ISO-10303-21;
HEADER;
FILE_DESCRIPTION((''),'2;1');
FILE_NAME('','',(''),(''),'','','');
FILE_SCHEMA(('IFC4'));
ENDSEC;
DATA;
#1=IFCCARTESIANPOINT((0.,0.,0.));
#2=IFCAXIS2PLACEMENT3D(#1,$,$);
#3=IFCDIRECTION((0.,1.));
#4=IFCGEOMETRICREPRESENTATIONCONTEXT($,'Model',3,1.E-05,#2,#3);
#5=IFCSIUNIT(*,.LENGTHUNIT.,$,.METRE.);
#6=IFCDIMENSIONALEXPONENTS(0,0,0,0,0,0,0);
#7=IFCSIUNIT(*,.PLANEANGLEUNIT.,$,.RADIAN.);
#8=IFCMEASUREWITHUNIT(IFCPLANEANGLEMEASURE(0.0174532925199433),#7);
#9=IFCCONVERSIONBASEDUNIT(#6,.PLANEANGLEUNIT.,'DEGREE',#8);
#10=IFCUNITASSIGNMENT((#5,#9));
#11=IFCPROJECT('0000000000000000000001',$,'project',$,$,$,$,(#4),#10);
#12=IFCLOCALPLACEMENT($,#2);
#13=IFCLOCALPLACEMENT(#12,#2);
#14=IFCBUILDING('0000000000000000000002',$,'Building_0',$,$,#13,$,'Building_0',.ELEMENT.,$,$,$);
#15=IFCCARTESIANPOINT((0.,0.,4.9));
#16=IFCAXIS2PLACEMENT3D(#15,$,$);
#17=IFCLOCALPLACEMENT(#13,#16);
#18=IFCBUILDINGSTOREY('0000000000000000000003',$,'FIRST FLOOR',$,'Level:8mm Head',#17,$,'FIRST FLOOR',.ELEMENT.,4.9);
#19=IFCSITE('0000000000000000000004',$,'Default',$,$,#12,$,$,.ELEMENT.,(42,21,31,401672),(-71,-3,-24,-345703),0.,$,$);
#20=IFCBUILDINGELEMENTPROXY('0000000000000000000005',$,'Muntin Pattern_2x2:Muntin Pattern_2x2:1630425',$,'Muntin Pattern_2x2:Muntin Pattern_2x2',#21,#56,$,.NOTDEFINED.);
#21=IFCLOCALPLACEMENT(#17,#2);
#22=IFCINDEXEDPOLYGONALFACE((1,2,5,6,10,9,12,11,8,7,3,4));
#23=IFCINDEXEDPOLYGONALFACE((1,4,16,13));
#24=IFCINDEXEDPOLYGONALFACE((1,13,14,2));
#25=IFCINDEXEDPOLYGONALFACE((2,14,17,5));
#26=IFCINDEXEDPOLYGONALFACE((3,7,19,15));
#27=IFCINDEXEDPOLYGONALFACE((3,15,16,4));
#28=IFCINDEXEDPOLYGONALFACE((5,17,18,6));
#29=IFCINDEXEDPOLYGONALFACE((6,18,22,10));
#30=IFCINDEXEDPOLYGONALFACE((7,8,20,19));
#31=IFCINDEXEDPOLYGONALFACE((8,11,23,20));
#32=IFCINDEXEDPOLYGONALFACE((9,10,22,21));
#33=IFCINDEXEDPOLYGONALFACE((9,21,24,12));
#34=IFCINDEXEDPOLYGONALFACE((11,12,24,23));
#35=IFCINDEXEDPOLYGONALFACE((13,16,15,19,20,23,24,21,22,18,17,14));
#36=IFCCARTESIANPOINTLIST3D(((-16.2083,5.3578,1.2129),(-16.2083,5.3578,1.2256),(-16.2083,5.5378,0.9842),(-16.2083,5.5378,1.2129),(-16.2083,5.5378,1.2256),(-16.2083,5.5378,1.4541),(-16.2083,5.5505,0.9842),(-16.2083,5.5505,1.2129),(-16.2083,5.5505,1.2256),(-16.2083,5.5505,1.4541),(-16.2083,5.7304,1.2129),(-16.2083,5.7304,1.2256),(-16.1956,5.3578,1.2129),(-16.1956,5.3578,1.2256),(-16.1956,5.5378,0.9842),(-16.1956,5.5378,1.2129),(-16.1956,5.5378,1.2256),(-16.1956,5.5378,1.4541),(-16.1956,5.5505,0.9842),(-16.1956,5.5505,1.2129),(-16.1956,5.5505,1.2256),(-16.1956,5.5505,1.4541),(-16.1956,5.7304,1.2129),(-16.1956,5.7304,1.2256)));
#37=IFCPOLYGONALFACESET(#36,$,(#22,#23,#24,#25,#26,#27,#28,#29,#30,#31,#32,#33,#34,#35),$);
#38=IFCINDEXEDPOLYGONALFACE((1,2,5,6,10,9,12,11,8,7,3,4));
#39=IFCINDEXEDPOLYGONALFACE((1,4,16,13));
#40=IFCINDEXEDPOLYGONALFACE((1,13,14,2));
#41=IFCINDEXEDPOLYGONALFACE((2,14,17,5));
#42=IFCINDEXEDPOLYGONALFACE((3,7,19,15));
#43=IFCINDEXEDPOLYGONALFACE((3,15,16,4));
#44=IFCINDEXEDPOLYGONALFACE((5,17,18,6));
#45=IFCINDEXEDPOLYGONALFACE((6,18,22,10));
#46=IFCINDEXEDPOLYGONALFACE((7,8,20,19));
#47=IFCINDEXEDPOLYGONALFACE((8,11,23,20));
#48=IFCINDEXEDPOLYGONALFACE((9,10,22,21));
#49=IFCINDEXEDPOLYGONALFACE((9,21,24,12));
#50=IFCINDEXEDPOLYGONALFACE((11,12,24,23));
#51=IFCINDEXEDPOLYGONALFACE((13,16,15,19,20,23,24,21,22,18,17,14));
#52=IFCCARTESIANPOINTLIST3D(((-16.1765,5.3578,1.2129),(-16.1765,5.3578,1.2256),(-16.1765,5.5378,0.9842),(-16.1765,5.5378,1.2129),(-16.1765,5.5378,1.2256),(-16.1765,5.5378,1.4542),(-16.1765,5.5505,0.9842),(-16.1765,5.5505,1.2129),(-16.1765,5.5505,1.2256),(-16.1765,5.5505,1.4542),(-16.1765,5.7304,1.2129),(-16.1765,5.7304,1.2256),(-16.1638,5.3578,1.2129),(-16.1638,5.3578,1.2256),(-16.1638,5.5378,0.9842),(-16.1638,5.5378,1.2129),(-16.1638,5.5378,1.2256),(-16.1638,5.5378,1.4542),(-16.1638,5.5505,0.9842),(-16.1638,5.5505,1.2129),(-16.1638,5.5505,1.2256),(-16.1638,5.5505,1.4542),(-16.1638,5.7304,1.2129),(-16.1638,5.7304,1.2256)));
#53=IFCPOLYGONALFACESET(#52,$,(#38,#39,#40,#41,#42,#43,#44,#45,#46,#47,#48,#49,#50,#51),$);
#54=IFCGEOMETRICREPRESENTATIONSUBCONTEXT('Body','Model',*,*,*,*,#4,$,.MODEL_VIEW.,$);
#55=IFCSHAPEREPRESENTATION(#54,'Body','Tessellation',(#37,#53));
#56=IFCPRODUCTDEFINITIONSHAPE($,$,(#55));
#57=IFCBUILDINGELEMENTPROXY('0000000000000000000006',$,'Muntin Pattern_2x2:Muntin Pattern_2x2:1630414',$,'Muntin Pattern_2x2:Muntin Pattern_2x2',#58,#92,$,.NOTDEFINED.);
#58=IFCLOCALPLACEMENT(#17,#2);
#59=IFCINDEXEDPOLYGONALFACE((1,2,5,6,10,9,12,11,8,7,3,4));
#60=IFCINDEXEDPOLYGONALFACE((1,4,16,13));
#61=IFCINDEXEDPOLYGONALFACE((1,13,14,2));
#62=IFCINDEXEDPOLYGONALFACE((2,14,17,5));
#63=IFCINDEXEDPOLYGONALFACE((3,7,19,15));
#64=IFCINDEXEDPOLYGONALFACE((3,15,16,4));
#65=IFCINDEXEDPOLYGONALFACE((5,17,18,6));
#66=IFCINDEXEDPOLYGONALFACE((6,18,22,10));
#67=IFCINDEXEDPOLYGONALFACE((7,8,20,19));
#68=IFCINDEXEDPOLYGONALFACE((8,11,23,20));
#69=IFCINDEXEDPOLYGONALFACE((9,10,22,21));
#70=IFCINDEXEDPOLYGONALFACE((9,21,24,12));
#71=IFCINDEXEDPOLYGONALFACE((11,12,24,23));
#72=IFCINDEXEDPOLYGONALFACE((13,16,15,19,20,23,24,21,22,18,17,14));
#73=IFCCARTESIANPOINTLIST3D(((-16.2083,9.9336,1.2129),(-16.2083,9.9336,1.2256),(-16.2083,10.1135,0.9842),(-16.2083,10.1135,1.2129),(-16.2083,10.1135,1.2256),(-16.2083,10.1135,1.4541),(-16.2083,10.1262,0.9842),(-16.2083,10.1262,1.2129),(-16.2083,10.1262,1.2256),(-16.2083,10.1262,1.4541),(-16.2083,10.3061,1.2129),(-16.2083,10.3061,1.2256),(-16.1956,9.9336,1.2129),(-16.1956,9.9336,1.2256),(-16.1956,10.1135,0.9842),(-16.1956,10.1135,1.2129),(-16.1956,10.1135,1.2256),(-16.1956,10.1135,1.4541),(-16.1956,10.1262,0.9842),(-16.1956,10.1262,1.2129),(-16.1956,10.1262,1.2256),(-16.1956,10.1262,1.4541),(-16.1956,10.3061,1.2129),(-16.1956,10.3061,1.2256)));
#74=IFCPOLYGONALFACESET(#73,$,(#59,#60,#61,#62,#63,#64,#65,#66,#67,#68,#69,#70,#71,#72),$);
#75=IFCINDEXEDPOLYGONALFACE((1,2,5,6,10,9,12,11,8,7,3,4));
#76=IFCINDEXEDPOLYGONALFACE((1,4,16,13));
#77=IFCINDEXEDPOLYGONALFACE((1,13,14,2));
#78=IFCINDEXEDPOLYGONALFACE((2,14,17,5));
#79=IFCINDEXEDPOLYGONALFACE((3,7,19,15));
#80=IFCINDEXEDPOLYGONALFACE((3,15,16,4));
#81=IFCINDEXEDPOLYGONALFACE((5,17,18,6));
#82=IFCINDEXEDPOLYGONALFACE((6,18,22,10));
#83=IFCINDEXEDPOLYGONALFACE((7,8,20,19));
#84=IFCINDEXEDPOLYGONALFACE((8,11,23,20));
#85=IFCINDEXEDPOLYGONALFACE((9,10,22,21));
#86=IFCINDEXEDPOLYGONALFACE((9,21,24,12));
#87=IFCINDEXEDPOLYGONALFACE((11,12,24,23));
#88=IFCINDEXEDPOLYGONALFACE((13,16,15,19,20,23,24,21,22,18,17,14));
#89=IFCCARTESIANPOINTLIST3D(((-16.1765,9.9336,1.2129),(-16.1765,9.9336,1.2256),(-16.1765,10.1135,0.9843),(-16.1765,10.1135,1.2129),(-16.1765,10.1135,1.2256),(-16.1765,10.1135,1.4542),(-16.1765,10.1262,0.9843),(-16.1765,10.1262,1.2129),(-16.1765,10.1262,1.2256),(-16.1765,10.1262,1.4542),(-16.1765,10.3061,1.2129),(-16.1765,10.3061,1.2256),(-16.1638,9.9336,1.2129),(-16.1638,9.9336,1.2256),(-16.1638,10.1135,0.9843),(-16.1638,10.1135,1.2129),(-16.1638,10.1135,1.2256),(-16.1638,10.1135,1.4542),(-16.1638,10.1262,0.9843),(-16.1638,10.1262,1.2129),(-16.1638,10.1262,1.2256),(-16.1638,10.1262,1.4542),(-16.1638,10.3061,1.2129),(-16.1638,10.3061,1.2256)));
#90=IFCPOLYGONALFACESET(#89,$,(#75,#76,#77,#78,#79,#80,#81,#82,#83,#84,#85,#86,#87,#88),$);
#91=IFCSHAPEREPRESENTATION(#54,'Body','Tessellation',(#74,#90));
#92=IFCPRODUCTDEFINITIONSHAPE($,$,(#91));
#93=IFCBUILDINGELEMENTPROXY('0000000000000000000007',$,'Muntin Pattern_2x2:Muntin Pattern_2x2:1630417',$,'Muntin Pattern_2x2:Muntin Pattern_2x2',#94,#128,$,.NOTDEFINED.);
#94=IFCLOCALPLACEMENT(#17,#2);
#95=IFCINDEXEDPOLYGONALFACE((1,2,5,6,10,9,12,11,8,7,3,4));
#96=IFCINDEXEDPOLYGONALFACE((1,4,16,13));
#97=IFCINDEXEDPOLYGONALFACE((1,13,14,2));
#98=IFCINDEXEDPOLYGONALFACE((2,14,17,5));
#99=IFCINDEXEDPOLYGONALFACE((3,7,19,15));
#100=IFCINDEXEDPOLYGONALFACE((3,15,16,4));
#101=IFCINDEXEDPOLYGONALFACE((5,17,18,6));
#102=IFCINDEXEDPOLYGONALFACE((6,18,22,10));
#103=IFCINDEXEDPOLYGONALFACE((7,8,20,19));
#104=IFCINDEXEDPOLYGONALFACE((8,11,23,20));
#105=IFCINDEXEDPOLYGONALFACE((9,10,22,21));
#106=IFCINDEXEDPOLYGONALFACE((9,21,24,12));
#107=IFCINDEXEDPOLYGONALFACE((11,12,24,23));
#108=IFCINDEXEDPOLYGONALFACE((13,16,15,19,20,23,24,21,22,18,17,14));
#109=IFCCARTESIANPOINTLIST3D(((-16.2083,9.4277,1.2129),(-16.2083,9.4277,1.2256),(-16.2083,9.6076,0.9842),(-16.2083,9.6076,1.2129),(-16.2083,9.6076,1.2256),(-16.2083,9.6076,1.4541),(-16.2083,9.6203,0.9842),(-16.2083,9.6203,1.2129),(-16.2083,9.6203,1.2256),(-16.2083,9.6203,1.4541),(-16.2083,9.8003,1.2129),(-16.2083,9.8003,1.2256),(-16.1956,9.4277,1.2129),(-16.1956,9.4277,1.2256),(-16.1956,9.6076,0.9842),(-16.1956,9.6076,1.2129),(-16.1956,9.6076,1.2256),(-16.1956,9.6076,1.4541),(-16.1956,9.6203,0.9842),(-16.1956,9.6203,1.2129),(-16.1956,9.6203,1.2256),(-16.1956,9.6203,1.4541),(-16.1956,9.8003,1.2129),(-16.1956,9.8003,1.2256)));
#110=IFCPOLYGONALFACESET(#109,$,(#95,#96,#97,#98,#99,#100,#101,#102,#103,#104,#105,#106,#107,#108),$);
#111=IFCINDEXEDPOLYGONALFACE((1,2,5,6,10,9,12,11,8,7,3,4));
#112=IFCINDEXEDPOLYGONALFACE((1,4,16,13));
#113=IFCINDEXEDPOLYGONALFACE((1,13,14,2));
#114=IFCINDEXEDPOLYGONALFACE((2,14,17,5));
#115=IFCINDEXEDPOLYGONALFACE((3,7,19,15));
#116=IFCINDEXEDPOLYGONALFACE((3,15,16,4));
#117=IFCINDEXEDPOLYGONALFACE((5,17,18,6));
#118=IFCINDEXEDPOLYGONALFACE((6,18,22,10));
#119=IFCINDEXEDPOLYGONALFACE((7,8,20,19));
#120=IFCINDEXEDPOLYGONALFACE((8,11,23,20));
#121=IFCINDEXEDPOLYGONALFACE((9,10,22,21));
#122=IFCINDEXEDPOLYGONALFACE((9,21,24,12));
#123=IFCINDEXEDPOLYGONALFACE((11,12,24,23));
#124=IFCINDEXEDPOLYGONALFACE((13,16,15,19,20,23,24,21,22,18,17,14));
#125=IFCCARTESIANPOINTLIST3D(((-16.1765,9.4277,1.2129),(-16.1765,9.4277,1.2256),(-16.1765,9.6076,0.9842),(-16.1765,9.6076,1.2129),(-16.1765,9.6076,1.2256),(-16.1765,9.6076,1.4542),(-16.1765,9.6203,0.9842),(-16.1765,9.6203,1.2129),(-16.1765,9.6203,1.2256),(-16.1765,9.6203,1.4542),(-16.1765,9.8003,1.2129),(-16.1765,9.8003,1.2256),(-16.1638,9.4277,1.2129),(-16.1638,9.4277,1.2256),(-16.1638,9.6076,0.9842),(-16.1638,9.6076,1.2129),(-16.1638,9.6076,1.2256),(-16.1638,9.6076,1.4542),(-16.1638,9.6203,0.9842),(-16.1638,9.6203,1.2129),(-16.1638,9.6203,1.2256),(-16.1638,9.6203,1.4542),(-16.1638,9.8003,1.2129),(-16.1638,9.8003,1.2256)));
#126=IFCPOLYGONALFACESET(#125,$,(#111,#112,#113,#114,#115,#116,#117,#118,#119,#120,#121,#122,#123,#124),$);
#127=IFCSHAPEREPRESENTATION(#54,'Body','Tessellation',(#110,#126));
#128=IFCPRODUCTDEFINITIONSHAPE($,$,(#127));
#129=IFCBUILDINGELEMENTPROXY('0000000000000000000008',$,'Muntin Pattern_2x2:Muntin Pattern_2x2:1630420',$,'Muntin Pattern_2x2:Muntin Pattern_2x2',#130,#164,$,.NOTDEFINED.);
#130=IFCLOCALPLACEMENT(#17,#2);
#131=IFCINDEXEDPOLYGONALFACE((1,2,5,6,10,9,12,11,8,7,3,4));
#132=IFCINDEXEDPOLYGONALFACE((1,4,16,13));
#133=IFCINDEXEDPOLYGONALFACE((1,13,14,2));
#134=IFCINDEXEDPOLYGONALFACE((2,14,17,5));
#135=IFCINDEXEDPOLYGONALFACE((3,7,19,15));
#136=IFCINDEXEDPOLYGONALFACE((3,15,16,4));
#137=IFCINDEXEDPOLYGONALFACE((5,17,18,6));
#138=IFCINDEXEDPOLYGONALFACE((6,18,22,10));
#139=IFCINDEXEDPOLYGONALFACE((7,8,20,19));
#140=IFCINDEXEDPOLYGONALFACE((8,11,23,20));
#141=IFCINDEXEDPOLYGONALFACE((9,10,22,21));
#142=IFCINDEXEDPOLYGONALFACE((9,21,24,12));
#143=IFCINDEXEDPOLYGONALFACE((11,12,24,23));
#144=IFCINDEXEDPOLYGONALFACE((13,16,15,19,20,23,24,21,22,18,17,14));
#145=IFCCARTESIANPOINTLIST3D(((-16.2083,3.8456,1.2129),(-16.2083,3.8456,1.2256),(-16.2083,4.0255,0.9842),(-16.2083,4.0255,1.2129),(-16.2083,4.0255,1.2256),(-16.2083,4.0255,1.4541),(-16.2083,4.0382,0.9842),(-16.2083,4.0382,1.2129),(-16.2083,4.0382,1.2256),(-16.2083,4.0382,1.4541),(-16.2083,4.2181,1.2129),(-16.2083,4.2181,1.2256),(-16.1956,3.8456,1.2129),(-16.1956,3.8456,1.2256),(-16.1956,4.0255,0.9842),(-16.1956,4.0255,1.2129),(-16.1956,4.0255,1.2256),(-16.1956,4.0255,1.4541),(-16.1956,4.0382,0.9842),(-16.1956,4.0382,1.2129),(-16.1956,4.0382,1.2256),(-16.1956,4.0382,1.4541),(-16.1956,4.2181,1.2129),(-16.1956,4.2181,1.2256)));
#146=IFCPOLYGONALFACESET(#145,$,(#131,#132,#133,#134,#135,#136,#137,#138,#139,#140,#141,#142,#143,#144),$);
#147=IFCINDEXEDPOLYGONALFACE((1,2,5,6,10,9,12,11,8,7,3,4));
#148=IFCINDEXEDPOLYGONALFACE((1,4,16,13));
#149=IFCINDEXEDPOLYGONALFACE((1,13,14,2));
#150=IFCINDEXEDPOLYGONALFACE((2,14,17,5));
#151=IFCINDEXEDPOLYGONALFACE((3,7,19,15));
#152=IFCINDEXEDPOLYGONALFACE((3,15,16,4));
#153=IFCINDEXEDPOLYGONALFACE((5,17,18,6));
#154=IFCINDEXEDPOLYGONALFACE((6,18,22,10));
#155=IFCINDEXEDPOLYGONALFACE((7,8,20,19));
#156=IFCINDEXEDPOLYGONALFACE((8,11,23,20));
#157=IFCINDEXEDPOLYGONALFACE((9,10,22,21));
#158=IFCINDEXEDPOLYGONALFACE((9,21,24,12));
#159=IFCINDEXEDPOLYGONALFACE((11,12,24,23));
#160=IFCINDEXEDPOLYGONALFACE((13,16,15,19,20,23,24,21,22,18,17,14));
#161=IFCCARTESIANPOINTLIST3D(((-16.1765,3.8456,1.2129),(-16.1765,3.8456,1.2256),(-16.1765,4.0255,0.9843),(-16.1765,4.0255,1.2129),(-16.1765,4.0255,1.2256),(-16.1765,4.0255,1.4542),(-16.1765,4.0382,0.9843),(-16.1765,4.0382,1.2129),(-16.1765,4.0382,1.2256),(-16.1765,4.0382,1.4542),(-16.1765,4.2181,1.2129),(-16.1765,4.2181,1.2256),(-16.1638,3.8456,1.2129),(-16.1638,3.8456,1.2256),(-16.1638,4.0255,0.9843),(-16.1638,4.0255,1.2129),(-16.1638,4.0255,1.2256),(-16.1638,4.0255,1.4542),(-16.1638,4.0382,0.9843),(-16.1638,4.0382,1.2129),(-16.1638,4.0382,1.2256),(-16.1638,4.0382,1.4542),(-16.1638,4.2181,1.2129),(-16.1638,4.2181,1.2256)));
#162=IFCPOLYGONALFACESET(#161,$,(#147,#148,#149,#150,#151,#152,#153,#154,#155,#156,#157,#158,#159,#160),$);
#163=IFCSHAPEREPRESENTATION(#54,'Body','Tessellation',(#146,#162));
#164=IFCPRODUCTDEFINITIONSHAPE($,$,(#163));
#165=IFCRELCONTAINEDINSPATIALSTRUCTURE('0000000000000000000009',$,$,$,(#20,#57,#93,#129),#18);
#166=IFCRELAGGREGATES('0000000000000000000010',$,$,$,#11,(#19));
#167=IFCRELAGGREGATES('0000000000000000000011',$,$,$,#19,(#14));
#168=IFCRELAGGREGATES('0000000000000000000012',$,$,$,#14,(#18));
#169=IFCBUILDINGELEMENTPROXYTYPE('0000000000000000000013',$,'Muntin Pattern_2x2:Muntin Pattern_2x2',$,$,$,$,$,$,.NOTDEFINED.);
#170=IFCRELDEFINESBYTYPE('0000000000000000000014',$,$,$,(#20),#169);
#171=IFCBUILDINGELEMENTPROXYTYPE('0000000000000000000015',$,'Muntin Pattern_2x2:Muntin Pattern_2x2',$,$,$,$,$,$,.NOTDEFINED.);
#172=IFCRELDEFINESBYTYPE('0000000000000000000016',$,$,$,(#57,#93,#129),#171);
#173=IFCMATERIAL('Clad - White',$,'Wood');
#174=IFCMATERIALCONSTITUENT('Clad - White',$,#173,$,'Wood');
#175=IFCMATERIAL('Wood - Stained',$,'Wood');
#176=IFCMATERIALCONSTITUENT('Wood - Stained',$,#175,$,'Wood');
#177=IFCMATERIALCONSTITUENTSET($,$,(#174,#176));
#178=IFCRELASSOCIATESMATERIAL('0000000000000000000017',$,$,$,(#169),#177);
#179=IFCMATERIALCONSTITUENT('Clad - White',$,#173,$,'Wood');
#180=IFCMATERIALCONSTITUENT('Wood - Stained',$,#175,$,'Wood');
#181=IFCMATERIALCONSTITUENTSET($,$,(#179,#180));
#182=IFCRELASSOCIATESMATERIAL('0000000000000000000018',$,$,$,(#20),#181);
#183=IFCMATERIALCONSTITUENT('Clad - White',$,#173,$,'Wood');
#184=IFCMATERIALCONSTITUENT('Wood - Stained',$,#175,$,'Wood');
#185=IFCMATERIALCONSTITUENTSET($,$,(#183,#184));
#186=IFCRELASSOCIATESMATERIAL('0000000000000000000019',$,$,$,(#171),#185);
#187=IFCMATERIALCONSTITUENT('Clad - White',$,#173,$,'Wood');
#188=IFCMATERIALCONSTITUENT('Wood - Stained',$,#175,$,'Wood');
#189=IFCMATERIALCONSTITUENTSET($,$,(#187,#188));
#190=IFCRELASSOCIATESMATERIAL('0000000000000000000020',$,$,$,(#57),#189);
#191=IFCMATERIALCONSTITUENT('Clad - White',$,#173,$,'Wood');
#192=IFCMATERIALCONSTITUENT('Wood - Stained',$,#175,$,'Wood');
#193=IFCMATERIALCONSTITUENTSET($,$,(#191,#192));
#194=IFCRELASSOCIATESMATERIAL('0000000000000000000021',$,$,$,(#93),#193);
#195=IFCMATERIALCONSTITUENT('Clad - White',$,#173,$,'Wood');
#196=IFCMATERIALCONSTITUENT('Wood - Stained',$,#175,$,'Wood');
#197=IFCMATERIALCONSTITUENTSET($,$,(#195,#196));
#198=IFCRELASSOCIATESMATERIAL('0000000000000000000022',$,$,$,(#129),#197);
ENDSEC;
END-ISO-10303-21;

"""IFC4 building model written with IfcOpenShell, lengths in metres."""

from ifc_helpers import new_model, entity, si_unit, converted_unit, direction, frame, origin, place, context, subcontext, project, spatial, indexed_curve, outline, extrude, source, transform, mapped, material, constituent, constituent_set, type_object, type_shapes, element, save


model = new_model("IFC4")

# Units and contexts
model_context = context("Model", 3, precision=1e-05, world=origin(), true_north=direction((0.0, 1.0)))
body_context = subcontext(model_context, "Body", "Model", "MODEL_VIEW")
ifc_project = project(units=[si_unit("LENGTHUNIT", "METRE"), converted_unit("PLANEANGLEUNIT", "DEGREE", entity("IfcPlaneAngleMeasure", 0.0174532925199433), si_unit("PLANEANGLEUNIT", "RADIAN"), dimensions=[0, 0, 0, 0, 0, 0, 0])], contexts=[model_context])

# Site, building, storey
site_placement = place(None, origin())
site = spatial("IfcSite", under=ifc_project, at=site_placement, Name="Default", CompositionType="ELEMENT", RefLatitude=(42, 21, 31, 401672), RefLongitude=(-71, -3, -24, -345703), RefElevation=0.0)
building_placement = place(site_placement, origin())
building = spatial("IfcBuilding", under=site, at=building_placement, Name="Building_0", LongName="Building_0", CompositionType="ELEMENT")
storey_placement = place(building_placement, frame((0.0, 0.0, 4.9)))
storey = spatial("IfcBuildingStorey", under=building, at=storey_placement, Name="FIRST FLOOR", ObjectType="Level:8mm Head", LongName="FIRST FLOOR", CompositionType="ELEMENT", Elevation=4.9)

# Shared definitions
ifc_material_1 = material(Name="Clad - White", Category="Wood")

# Building element proxies
ifc_material_2 = material(Name="Wood - Stained", Category="Wood")
ifc_constituent_1 = constituent(ifc_material_1, Name="Clad - White", Category="Wood")
ifc_constituent_2 = constituent(ifc_material_2, Name="Wood - Stained", Category="Wood")
ifc_constituent_set_1 = constituent_set(constituents=[ifc_constituent_1, ifc_constituent_2])
building_element_proxy_type_1 = type_object("IfcBuildingElementProxyType", Name="Muntin Pattern_2x2:Muntin Pattern_2x2", PredefinedType="NOTDEFINED", material=ifc_constituent_set_1)
shared_shape_1 = source(origin(), body_context, "Body", "SweptSolid", [
    extrude(outline(indexed_curve([(0.0064, -0.0064), (0.2349, -0.0064), (0.2349, 0.0063), (0.0064, 0.0063), (0.0064, 0.1863), (-0.0063, 0.1863), (-0.0063, 0.0063), (-0.235, 0.0063), (-0.235, -0.0064), (-0.0063, -0.0064), (-0.0063, -0.1863), (0.0064, -0.1863), (0.0064, -0.0064)], self_intersect=False)), frame((0.0, 0.0095, 0.235), z_axis=(0.0, 1.0, 0.0), x_axis=(0.0, 0.0, 1.0)), (0.0, 0.0, 1.0), 0.0127),
    extrude(outline(indexed_curve([(0.0064, -0.0064), (0.235, -0.0064), (0.235, 0.0063), (0.0064, 0.0063), (0.0064, 0.1863), (-0.0063, 0.1863), (-0.0063, 0.0063), (-0.235, 0.0063), (-0.235, -0.0064), (-0.0063, -0.0064), (-0.0063, -0.1863), (0.0064, -0.1863), (0.0064, -0.0064)], self_intersect=False)), frame((0.0, -0.0222, 0.235), z_axis=(0.0, 1.0, 0.0), x_axis=(0.0, 0.0, 1.0)), (0.0, 0.0, 1.0), 0.0127),
])
type_shapes(building_element_proxy_type_1, [shared_shape_1])
ifc_constituent_3 = constituent(ifc_material_1, Name="Clad - White", Category="Wood")
ifc_constituent_4 = constituent(ifc_material_2, Name="Wood - Stained", Category="Wood")
ifc_constituent_set_2 = constituent_set(constituents=[ifc_constituent_3, ifc_constituent_4])
proxy_1_placement = place(storey_placement, frame((-16.1861, 5.5441, 0.9842), z_axis=(0.0, 0.0, 1.0), x_axis=(0.0, 1.0, 0.0)))
element("IfcBuildingElementProxy", 1, at=proxy_1_placement, inside=storey, type_object=building_element_proxy_type_1, material=ifc_constituent_set_2, Name="Muntin Pattern_2x2:Muntin Pattern_2x2:1630425", ObjectType="Muntin Pattern_2x2:Muntin Pattern_2x2", PredefinedType="NOTDEFINED", context=body_context, shape_type="MappedRepresentation", body=[
    mapped(shared_shape_1, transform((0.0, 0.0, 0.0), scale=1.0)),
])
ifc_constituent_5 = constituent(ifc_material_1, Name="Clad - White", Category="Wood")
ifc_constituent_6 = constituent(ifc_material_2, Name="Wood - Stained", Category="Wood")
ifc_constituent_set_3 = constituent_set(constituents=[ifc_constituent_5, ifc_constituent_6])
ifc_constituent_7 = constituent(ifc_material_1, Name="Clad - White", Category="Wood")
ifc_constituent_8 = constituent(ifc_material_2, Name="Wood - Stained", Category="Wood")
ifc_constituent_set_4 = constituent_set(constituents=[ifc_constituent_7, ifc_constituent_8])
building_element_proxy_type_2 = type_object("IfcBuildingElementProxyType", Name="Muntin Pattern_2x2:Muntin Pattern_2x2", PredefinedType="NOTDEFINED", material=ifc_constituent_set_4)
shared_shape_2 = source(origin(), body_context, "Body", "SweptSolid", [
    extrude(outline(indexed_curve([(0.0064, -0.0064), (0.2349, -0.0064), (0.2349, 0.0063), (0.0064, 0.0063), (0.0064, 0.1863), (-0.0063, 0.1863), (-0.0063, 0.0063), (-0.235, 0.0063), (-0.235, -0.0064), (-0.0063, -0.0064), (-0.0063, -0.1863), (0.0064, -0.1863), (0.0064, -0.0064)], self_intersect=False)), frame((0.0, -0.0222, 0.2349), z_axis=(0.0, 1.0, 0.0), x_axis=(0.0, 0.0, 1.0)), (0.0, 0.0, 1.0), 0.0127),
    extrude(outline(indexed_curve([(0.0064, -0.0064), (0.235, -0.0064), (0.235, 0.0063), (0.0064, 0.0063), (0.0064, 0.1863), (-0.0063, 0.1863), (-0.0063, 0.0063), (-0.235, 0.0063), (-0.235, -0.0064), (-0.0063, -0.0064), (-0.0063, -0.1863), (0.0064, -0.1863), (0.0064, -0.0064)], self_intersect=False)), frame((0.0, 0.0095, 0.235), z_axis=(0.0, 1.0, 0.0), x_axis=(0.0, 0.0, 1.0)), (0.0, 0.0, 1.0), 0.0127),
])
type_shapes(building_element_proxy_type_2, [shared_shape_2])
proxy_2_placement = place(storey_placement, frame((-16.1861, 10.1199, 0.9843), z_axis=(0.0, 0.0, 1.0), x_axis=(0.0, -1.0, 0.0)))
element("IfcBuildingElementProxy", 2, at=proxy_2_placement, inside=storey, type_object=building_element_proxy_type_2, material=ifc_constituent_set_3, Name="Muntin Pattern_2x2:Muntin Pattern_2x2:1630414", ObjectType="Muntin Pattern_2x2:Muntin Pattern_2x2", PredefinedType="NOTDEFINED", context=body_context, shape_type="MappedRepresentation", body=[
    mapped(shared_shape_2, transform((0.0, 0.0, 0.0), scale=1.0)),
])
ifc_constituent_9 = constituent(ifc_material_1, Name="Clad - White", Category="Wood")
ifc_constituent_10 = constituent(ifc_material_2, Name="Wood - Stained", Category="Wood")
ifc_constituent_set_5 = constituent_set(constituents=[ifc_constituent_9, ifc_constituent_10])
proxy_3_placement = place(storey_placement, frame((-16.1861, 9.614, 0.9842), z_axis=(0.0, 0.0, 1.0), x_axis=(0.0, -1.0, 0.0)))
element("IfcBuildingElementProxy", 3, at=proxy_3_placement, inside=storey, type_object=building_element_proxy_type_2, material=ifc_constituent_set_5, Name="Muntin Pattern_2x2:Muntin Pattern_2x2:1630417", ObjectType="Muntin Pattern_2x2:Muntin Pattern_2x2", PredefinedType="NOTDEFINED", context=body_context, shape_type="MappedRepresentation", body=[
    mapped(shared_shape_2, transform((0.0, 0.0, 0.0), scale=1.0)),
])
ifc_constituent_11 = constituent(ifc_material_1, Name="Clad - White", Category="Wood")
ifc_constituent_12 = constituent(ifc_material_2, Name="Wood - Stained", Category="Wood")
ifc_constituent_set_6 = constituent_set(constituents=[ifc_constituent_11, ifc_constituent_12])
proxy_4_placement = place(storey_placement, frame((-16.1861, 4.0319, 0.9843), z_axis=(0.0, 0.0, 1.0), x_axis=(0.0, -1.0, 0.0)))
element("IfcBuildingElementProxy", 4, at=proxy_4_placement, inside=storey, type_object=building_element_proxy_type_2, material=ifc_constituent_set_6, Name="Muntin Pattern_2x2:Muntin Pattern_2x2:1630420", ObjectType="Muntin Pattern_2x2:Muntin Pattern_2x2", PredefinedType="NOTDEFINED", context=body_context, shape_type="MappedRepresentation", body=[
    mapped(shared_shape_2, transform((0.0, 0.0, 0.0), scale=1.0)),
])

save(model, "model.ifc")
